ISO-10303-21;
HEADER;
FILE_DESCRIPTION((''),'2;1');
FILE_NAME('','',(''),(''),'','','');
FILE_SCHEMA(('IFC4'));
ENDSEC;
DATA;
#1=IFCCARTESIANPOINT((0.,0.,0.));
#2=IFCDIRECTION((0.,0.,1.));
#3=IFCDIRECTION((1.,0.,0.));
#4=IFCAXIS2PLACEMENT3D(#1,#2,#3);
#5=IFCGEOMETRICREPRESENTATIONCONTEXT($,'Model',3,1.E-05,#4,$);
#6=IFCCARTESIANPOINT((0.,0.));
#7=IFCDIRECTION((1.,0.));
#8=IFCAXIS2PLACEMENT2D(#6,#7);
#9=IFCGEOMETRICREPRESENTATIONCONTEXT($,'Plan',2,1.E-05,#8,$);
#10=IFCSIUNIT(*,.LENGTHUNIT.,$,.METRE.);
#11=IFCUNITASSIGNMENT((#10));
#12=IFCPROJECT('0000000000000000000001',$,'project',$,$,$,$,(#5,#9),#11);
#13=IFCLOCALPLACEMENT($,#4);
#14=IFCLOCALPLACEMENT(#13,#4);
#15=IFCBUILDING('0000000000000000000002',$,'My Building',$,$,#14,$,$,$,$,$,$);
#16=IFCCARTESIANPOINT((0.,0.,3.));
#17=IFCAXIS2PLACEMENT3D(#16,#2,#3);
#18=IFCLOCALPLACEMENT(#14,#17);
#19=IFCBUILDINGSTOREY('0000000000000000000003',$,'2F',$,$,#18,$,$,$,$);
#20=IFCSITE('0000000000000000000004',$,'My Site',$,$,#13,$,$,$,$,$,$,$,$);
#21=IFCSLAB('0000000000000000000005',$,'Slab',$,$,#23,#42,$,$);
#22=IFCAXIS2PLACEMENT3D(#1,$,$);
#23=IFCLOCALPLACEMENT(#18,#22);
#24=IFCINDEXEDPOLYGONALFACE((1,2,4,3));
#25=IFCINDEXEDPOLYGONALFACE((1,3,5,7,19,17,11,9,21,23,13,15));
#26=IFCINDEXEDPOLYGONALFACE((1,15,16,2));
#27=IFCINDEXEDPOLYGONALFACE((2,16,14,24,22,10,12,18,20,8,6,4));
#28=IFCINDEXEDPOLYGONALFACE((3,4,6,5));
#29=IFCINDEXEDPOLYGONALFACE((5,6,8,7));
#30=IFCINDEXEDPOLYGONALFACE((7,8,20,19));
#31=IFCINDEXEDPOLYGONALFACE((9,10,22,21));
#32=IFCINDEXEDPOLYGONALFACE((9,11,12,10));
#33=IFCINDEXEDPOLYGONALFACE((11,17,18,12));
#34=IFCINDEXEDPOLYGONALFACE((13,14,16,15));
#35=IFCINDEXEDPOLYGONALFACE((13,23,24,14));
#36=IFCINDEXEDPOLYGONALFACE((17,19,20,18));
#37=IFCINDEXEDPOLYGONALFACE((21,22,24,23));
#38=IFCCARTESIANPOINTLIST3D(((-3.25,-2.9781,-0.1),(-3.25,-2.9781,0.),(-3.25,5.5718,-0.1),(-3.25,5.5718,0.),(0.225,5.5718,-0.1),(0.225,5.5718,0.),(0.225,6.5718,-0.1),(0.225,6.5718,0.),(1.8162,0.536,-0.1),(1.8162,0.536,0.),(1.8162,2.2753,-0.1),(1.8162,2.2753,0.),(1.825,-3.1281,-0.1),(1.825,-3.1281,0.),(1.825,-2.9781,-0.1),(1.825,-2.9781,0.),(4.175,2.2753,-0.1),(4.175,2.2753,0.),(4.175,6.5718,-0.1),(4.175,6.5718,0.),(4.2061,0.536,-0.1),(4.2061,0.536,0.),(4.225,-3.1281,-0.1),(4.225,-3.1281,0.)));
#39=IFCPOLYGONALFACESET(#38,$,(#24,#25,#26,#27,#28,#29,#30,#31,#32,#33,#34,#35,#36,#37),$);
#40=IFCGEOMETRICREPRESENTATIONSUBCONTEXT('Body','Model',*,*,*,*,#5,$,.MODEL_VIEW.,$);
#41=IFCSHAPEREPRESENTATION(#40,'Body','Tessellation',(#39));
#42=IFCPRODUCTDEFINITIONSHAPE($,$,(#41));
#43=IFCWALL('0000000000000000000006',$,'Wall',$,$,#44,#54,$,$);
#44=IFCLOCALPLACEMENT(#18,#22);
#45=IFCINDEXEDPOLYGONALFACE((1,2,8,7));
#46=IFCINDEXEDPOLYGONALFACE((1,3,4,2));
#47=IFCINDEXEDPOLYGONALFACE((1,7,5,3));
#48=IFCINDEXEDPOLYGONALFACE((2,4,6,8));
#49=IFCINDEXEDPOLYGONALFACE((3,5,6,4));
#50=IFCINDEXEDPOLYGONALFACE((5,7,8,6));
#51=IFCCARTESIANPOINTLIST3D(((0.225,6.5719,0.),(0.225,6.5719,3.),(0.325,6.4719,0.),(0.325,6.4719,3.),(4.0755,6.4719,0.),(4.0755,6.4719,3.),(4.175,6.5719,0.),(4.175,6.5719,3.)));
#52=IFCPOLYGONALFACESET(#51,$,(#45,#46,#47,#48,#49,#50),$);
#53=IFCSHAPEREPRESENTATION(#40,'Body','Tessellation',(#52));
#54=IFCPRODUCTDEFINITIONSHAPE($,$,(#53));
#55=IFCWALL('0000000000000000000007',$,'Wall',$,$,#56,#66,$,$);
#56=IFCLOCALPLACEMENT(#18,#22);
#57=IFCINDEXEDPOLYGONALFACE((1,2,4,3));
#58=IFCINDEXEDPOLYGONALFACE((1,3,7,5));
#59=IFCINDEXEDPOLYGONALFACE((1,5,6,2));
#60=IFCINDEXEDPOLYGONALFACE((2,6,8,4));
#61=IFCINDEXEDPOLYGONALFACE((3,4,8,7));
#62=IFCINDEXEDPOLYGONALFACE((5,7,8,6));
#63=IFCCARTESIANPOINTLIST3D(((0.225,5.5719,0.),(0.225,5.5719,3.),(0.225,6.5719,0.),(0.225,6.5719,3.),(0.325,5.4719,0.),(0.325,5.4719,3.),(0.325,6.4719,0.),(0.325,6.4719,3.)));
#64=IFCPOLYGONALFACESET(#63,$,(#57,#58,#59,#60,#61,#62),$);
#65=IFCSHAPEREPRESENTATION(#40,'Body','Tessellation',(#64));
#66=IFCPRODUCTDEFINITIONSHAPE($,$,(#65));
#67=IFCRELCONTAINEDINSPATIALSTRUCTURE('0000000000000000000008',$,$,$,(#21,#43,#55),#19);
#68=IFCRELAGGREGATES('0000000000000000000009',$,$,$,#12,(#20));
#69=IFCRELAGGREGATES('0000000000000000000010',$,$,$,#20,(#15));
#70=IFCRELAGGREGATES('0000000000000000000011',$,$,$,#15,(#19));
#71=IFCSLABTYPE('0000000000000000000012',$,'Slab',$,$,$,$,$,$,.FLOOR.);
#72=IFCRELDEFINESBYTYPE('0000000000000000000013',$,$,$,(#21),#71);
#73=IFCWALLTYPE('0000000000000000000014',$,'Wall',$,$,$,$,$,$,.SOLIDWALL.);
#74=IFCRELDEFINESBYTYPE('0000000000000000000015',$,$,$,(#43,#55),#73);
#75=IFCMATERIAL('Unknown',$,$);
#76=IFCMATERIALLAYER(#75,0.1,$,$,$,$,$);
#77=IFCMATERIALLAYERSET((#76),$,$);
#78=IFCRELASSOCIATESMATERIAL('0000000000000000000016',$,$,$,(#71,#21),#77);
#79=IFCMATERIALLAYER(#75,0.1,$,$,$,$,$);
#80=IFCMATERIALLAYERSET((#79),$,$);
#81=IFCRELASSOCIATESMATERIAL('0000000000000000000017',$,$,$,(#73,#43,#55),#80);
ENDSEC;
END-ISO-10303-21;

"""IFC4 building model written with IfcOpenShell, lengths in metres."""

from ifc_helpers import new_model, si_unit, frame, origin_with_axes, origin_2d_with_axis, place, context, subcontext, project, spatial, line, indexed_curve, outline, extrude, material, layer, layer_set, layer_usage, type_object, element, save


model = new_model("IFC4")

# Units and contexts
model_context = context("Model", 3, precision=1e-05, world=origin_with_axes())
plan_context = context("Plan", 2, precision=1e-05, world=origin_2d_with_axis())
body_context_1 = subcontext(model_context, "Body", "Model", "MODEL_VIEW")
ifc_project = project(units=[si_unit("LENGTHUNIT", "METRE")], contexts=[model_context, plan_context])

# Site, building, storey
site_placement = place(None, origin_with_axes())
site = spatial("IfcSite", under=ifc_project, at=site_placement, Name="My Site")
building_placement = place(site_placement, origin_with_axes())
building = spatial("IfcBuilding", under=site, at=building_placement, Name="My Building")
storey_placement = place(building_placement, frame((0.0, 0.0, 3.0), z_axis=(0.0, 0.0, 1.0), x_axis=(1.0, 0.0, 0.0)))
storey = spatial("IfcBuildingStorey", under=building, at=storey_placement, Name="2F")

# Slab
ifc_material = material(Name="Unknown")
ifc_layer_1 = layer(ifc_material, 0.1)
ifc_layer_set_1 = layer_set([ifc_layer_1])
ifc_layer_usage_1 = layer_usage(ifc_layer_set_1, "AXIS3", "POSITIVE", -0.1)
slab_type = type_object("IfcSlabType", Name="Slab", PredefinedType="FLOOR", material=ifc_layer_set_1)
slab_placement = place(storey_placement, frame((4.225, -3.1281, 0.0), z_axis=(0.0, 0.0, 1.0), x_axis=(1.0, 0.0, 0.0)))
element("IfcSlab", 1, at=slab_placement, inside=storey, type_object=slab_type, material=ifc_layer_usage_1, Name="Slab", context=body_context_1, shape_type="SweptSolid", body=[
    extrude(outline(indexed_curve([(-0.0189, 3.6641), (-2.4088, 3.6641), (-2.4088, 5.4034), (-0.05, 5.4034), (-0.05, 9.7), (-4.0, 9.7), (-4.0, 8.7), (-7.475, 8.7), (-7.475, 0.15), (-2.4, 0.15), (-2.4, 0.0), (0.0, 0.0), (-0.0189, 3.6641)])), frame((0.0, 0.0, -0.1), z_axis=(0.0, 0.0, 1.0), x_axis=(1.0, 0.0, 0.0)), (0.0, 0.0, 1.0), 0.1),
])

# Walls
ifc_layer_2 = layer(ifc_material, 0.1)
ifc_layer_set_2 = layer_set([ifc_layer_2])
ifc_layer_usage_2 = layer_usage(ifc_layer_set_2, "AXIS2", "POSITIVE", 0.0)
wall_type = type_object("IfcWallType", Name="Wall", PredefinedType="SOLIDWALL", material=ifc_layer_set_2)
wall_1_placement = place(storey_placement, frame((4.175, 6.5719, 0.0), z_axis=(0.0, 0.0, 1.0), x_axis=(-1.0, 0.0, 0.0)))
element("IfcWall", 2, at=wall_1_placement, inside=storey, type_object=wall_type, material=ifc_layer_usage_2, Name="Wall", context=body_context_1, shape_type="SweptSolid", body=[
    extrude(outline(indexed_curve([(0.0, 0.0), (0.0995, 0.1), (3.85, 0.1), (3.95, 0.0)], segments=[line(1, 2, 3, 4, 1)])), origin_with_axes(), (0.0, 0.0, 1.0), 3.0),
])
ifc_layer_usage_3 = layer_usage(ifc_layer_set_2, "AXIS2", "POSITIVE", 0.0)
wall_2_placement = place(storey_placement, frame((0.225, 6.5719, 0.0), z_axis=(0.0, 0.0, 1.0), x_axis=(0.0, -1.0, 0.0)))
element("IfcWall", 3, at=wall_2_placement, inside=storey, type_object=wall_type, material=ifc_layer_usage_3, Name="Wall", context=body_context_1, shape_type="SweptSolid", body=[
    extrude(outline(indexed_curve([(0.0, 0.0), (0.1, 0.1), (1.1, 0.1), (1.0, 0.0)], segments=[line(1, 2, 3, 4, 1)])), origin_with_axes(), (0.0, 0.0, 1.0), 3.0),
])

save(model, "model.ifc")
